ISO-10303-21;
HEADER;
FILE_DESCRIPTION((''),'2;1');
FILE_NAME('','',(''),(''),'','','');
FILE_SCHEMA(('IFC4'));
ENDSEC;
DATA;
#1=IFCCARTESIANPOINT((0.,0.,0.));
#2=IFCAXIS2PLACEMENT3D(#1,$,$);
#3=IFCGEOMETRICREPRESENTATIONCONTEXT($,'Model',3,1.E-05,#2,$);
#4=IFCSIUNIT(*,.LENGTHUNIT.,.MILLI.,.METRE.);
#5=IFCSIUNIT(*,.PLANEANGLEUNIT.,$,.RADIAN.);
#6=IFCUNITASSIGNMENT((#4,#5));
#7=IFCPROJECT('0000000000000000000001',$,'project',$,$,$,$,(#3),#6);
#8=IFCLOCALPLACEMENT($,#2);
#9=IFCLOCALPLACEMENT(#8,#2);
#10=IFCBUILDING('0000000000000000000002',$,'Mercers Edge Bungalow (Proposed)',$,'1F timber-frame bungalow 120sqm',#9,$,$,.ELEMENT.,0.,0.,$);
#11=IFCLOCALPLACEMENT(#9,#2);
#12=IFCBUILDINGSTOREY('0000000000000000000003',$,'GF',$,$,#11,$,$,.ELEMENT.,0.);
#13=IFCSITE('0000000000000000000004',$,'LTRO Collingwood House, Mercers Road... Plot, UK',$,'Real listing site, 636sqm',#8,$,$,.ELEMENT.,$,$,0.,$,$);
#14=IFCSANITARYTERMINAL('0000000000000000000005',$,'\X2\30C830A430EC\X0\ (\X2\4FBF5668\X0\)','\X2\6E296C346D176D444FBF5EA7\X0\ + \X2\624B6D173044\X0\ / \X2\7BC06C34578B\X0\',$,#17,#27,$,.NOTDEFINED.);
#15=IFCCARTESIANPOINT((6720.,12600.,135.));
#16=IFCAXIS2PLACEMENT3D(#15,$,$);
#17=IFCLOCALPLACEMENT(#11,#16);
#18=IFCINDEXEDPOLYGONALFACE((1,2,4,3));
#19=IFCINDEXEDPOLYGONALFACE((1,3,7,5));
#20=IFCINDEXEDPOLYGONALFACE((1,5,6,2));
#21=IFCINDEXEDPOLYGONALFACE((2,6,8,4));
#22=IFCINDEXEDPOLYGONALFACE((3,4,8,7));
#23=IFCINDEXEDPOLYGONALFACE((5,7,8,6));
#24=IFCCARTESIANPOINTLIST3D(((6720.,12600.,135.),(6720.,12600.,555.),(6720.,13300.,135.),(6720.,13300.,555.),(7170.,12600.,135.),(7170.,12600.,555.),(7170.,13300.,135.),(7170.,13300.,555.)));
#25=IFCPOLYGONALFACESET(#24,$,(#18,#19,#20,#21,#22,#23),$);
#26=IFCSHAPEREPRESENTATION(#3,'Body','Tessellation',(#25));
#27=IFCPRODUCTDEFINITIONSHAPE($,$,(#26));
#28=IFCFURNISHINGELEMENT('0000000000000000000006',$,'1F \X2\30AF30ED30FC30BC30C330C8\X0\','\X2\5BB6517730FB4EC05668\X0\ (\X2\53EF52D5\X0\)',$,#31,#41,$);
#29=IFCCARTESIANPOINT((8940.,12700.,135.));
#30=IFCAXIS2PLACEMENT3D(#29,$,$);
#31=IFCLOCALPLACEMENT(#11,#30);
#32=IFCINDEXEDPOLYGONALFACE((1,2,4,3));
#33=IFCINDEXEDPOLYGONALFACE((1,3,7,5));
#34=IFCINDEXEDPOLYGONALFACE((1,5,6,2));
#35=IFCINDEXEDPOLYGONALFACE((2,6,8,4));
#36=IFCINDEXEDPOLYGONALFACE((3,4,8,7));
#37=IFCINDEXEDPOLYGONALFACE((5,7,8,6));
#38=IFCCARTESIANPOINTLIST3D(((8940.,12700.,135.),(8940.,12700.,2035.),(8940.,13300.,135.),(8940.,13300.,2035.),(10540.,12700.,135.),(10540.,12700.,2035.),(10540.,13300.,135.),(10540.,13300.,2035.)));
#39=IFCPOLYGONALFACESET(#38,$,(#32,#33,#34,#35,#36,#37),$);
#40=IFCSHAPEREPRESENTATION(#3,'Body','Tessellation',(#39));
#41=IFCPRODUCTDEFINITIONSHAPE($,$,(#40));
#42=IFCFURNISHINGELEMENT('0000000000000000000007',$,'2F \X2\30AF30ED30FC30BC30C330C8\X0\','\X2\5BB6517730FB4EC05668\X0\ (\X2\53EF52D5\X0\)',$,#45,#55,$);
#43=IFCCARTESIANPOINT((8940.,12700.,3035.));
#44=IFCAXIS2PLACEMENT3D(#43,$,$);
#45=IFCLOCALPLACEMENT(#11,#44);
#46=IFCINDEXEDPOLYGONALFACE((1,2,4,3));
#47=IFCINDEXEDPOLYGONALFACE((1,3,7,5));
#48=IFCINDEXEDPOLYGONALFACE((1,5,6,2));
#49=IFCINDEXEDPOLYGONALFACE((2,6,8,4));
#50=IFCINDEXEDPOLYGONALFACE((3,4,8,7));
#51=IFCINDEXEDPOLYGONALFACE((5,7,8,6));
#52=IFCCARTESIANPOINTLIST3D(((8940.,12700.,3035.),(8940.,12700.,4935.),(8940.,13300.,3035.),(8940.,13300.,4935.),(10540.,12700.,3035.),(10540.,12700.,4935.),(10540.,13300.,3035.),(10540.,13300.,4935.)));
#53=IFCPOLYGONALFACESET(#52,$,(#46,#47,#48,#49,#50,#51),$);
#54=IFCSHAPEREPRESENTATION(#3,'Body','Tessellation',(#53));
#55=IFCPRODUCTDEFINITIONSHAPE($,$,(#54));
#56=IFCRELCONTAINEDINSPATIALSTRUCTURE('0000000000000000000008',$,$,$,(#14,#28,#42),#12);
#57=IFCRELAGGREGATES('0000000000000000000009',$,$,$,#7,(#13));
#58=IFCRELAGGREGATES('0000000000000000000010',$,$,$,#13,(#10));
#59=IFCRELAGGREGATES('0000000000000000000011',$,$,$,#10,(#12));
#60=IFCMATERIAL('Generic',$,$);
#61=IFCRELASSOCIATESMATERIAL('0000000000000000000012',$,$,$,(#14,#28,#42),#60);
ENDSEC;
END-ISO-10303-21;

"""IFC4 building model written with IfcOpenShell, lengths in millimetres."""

from ifc_helpers import new_model, si_unit, frame, frame_2d, origin, place, context, project, spatial, rectangle, extrude, material, element, save


model = new_model("IFC4")

# Units and contexts
model_context = context("Model", 3, precision=1e-05, world=origin())
ifc_project = project(units=[si_unit("LENGTHUNIT", "METRE", prefix="MILLI"), si_unit("PLANEANGLEUNIT", "RADIAN")], contexts=[model_context])

# Site, building, storey
site_placement = place(None, origin())
site = spatial("IfcSite", under=ifc_project, at=site_placement, Name="LTRO Collingwood House, Mercers Road... Plot, UK", ObjectType="Real listing site, 636sqm", CompositionType="ELEMENT", RefElevation=0.0)
building_placement = place(site_placement, origin())
building = spatial("IfcBuilding", under=site, at=building_placement, Name="Mercers Edge Bungalow (Proposed)", ObjectType="1F timber-frame bungalow 120sqm", CompositionType="ELEMENT", ElevationOfRefHeight=0.0, ElevationOfTerrain=0.0)
storey_placement = place(building_placement, origin())
storey = spatial("IfcBuildingStorey", under=building, at=storey_placement, Name="GF", CompositionType="ELEMENT", Elevation=0.0)

# Sanitary terminal
ifc_material_1 = material(Name="Generic")
sanitary_terminal_1_placement = place(storey_placement, frame((6720.0, 12600.0, 135.0)))
element("IfcSanitaryTerminal", 1, at=sanitary_terminal_1_placement, inside=storey, material=ifc_material_1, Name="トイレ (便器)", Description="温水洗浄便座 + 手洗い / 節水型", PredefinedType="NOTDEFINED", context=model_context, shape_type="SweptSolid", body=[
    extrude(rectangle(XDim=450.0, YDim=700.0, at=frame_2d((225.0, 350.0))), frame((6720.0, 12600.0, 135.0)), (0.0, 0.0, 1.0), 420.0),
])

# Furnishing elements
furnishing_1_placement = place(storey_placement, frame((8940.0, 12700.0, 135.0)))
element("IfcFurnishingElement", 2, at=furnishing_1_placement, inside=storey, material=ifc_material_1, Name="1F クローゼット", Description="家具・什器 (可動)", context=model_context, shape_type="SweptSolid", body=[
    extrude(rectangle(XDim=1600.0, YDim=600.0, at=frame_2d((800.0, 300.0))), frame((8940.0, 12700.0, 135.0)), (0.0, 0.0, 1.0), 1900.0),
])
furnishing_2_placement = place(storey_placement, frame((8940.0, 12700.0, 3035.0)))
element("IfcFurnishingElement", 3, at=furnishing_2_placement, inside=storey, material=ifc_material_1, Name="2F クローゼット", Description="家具・什器 (可動)", context=model_context, shape_type="SweptSolid", body=[
    extrude(rectangle(XDim=1600.0, YDim=600.0, at=frame_2d((800.0, 300.0))), frame((8940.0, 12700.0, 3035.0)), (0.0, 0.0, 1.0), 1900.0),
])

save(model, "model.ifc")
